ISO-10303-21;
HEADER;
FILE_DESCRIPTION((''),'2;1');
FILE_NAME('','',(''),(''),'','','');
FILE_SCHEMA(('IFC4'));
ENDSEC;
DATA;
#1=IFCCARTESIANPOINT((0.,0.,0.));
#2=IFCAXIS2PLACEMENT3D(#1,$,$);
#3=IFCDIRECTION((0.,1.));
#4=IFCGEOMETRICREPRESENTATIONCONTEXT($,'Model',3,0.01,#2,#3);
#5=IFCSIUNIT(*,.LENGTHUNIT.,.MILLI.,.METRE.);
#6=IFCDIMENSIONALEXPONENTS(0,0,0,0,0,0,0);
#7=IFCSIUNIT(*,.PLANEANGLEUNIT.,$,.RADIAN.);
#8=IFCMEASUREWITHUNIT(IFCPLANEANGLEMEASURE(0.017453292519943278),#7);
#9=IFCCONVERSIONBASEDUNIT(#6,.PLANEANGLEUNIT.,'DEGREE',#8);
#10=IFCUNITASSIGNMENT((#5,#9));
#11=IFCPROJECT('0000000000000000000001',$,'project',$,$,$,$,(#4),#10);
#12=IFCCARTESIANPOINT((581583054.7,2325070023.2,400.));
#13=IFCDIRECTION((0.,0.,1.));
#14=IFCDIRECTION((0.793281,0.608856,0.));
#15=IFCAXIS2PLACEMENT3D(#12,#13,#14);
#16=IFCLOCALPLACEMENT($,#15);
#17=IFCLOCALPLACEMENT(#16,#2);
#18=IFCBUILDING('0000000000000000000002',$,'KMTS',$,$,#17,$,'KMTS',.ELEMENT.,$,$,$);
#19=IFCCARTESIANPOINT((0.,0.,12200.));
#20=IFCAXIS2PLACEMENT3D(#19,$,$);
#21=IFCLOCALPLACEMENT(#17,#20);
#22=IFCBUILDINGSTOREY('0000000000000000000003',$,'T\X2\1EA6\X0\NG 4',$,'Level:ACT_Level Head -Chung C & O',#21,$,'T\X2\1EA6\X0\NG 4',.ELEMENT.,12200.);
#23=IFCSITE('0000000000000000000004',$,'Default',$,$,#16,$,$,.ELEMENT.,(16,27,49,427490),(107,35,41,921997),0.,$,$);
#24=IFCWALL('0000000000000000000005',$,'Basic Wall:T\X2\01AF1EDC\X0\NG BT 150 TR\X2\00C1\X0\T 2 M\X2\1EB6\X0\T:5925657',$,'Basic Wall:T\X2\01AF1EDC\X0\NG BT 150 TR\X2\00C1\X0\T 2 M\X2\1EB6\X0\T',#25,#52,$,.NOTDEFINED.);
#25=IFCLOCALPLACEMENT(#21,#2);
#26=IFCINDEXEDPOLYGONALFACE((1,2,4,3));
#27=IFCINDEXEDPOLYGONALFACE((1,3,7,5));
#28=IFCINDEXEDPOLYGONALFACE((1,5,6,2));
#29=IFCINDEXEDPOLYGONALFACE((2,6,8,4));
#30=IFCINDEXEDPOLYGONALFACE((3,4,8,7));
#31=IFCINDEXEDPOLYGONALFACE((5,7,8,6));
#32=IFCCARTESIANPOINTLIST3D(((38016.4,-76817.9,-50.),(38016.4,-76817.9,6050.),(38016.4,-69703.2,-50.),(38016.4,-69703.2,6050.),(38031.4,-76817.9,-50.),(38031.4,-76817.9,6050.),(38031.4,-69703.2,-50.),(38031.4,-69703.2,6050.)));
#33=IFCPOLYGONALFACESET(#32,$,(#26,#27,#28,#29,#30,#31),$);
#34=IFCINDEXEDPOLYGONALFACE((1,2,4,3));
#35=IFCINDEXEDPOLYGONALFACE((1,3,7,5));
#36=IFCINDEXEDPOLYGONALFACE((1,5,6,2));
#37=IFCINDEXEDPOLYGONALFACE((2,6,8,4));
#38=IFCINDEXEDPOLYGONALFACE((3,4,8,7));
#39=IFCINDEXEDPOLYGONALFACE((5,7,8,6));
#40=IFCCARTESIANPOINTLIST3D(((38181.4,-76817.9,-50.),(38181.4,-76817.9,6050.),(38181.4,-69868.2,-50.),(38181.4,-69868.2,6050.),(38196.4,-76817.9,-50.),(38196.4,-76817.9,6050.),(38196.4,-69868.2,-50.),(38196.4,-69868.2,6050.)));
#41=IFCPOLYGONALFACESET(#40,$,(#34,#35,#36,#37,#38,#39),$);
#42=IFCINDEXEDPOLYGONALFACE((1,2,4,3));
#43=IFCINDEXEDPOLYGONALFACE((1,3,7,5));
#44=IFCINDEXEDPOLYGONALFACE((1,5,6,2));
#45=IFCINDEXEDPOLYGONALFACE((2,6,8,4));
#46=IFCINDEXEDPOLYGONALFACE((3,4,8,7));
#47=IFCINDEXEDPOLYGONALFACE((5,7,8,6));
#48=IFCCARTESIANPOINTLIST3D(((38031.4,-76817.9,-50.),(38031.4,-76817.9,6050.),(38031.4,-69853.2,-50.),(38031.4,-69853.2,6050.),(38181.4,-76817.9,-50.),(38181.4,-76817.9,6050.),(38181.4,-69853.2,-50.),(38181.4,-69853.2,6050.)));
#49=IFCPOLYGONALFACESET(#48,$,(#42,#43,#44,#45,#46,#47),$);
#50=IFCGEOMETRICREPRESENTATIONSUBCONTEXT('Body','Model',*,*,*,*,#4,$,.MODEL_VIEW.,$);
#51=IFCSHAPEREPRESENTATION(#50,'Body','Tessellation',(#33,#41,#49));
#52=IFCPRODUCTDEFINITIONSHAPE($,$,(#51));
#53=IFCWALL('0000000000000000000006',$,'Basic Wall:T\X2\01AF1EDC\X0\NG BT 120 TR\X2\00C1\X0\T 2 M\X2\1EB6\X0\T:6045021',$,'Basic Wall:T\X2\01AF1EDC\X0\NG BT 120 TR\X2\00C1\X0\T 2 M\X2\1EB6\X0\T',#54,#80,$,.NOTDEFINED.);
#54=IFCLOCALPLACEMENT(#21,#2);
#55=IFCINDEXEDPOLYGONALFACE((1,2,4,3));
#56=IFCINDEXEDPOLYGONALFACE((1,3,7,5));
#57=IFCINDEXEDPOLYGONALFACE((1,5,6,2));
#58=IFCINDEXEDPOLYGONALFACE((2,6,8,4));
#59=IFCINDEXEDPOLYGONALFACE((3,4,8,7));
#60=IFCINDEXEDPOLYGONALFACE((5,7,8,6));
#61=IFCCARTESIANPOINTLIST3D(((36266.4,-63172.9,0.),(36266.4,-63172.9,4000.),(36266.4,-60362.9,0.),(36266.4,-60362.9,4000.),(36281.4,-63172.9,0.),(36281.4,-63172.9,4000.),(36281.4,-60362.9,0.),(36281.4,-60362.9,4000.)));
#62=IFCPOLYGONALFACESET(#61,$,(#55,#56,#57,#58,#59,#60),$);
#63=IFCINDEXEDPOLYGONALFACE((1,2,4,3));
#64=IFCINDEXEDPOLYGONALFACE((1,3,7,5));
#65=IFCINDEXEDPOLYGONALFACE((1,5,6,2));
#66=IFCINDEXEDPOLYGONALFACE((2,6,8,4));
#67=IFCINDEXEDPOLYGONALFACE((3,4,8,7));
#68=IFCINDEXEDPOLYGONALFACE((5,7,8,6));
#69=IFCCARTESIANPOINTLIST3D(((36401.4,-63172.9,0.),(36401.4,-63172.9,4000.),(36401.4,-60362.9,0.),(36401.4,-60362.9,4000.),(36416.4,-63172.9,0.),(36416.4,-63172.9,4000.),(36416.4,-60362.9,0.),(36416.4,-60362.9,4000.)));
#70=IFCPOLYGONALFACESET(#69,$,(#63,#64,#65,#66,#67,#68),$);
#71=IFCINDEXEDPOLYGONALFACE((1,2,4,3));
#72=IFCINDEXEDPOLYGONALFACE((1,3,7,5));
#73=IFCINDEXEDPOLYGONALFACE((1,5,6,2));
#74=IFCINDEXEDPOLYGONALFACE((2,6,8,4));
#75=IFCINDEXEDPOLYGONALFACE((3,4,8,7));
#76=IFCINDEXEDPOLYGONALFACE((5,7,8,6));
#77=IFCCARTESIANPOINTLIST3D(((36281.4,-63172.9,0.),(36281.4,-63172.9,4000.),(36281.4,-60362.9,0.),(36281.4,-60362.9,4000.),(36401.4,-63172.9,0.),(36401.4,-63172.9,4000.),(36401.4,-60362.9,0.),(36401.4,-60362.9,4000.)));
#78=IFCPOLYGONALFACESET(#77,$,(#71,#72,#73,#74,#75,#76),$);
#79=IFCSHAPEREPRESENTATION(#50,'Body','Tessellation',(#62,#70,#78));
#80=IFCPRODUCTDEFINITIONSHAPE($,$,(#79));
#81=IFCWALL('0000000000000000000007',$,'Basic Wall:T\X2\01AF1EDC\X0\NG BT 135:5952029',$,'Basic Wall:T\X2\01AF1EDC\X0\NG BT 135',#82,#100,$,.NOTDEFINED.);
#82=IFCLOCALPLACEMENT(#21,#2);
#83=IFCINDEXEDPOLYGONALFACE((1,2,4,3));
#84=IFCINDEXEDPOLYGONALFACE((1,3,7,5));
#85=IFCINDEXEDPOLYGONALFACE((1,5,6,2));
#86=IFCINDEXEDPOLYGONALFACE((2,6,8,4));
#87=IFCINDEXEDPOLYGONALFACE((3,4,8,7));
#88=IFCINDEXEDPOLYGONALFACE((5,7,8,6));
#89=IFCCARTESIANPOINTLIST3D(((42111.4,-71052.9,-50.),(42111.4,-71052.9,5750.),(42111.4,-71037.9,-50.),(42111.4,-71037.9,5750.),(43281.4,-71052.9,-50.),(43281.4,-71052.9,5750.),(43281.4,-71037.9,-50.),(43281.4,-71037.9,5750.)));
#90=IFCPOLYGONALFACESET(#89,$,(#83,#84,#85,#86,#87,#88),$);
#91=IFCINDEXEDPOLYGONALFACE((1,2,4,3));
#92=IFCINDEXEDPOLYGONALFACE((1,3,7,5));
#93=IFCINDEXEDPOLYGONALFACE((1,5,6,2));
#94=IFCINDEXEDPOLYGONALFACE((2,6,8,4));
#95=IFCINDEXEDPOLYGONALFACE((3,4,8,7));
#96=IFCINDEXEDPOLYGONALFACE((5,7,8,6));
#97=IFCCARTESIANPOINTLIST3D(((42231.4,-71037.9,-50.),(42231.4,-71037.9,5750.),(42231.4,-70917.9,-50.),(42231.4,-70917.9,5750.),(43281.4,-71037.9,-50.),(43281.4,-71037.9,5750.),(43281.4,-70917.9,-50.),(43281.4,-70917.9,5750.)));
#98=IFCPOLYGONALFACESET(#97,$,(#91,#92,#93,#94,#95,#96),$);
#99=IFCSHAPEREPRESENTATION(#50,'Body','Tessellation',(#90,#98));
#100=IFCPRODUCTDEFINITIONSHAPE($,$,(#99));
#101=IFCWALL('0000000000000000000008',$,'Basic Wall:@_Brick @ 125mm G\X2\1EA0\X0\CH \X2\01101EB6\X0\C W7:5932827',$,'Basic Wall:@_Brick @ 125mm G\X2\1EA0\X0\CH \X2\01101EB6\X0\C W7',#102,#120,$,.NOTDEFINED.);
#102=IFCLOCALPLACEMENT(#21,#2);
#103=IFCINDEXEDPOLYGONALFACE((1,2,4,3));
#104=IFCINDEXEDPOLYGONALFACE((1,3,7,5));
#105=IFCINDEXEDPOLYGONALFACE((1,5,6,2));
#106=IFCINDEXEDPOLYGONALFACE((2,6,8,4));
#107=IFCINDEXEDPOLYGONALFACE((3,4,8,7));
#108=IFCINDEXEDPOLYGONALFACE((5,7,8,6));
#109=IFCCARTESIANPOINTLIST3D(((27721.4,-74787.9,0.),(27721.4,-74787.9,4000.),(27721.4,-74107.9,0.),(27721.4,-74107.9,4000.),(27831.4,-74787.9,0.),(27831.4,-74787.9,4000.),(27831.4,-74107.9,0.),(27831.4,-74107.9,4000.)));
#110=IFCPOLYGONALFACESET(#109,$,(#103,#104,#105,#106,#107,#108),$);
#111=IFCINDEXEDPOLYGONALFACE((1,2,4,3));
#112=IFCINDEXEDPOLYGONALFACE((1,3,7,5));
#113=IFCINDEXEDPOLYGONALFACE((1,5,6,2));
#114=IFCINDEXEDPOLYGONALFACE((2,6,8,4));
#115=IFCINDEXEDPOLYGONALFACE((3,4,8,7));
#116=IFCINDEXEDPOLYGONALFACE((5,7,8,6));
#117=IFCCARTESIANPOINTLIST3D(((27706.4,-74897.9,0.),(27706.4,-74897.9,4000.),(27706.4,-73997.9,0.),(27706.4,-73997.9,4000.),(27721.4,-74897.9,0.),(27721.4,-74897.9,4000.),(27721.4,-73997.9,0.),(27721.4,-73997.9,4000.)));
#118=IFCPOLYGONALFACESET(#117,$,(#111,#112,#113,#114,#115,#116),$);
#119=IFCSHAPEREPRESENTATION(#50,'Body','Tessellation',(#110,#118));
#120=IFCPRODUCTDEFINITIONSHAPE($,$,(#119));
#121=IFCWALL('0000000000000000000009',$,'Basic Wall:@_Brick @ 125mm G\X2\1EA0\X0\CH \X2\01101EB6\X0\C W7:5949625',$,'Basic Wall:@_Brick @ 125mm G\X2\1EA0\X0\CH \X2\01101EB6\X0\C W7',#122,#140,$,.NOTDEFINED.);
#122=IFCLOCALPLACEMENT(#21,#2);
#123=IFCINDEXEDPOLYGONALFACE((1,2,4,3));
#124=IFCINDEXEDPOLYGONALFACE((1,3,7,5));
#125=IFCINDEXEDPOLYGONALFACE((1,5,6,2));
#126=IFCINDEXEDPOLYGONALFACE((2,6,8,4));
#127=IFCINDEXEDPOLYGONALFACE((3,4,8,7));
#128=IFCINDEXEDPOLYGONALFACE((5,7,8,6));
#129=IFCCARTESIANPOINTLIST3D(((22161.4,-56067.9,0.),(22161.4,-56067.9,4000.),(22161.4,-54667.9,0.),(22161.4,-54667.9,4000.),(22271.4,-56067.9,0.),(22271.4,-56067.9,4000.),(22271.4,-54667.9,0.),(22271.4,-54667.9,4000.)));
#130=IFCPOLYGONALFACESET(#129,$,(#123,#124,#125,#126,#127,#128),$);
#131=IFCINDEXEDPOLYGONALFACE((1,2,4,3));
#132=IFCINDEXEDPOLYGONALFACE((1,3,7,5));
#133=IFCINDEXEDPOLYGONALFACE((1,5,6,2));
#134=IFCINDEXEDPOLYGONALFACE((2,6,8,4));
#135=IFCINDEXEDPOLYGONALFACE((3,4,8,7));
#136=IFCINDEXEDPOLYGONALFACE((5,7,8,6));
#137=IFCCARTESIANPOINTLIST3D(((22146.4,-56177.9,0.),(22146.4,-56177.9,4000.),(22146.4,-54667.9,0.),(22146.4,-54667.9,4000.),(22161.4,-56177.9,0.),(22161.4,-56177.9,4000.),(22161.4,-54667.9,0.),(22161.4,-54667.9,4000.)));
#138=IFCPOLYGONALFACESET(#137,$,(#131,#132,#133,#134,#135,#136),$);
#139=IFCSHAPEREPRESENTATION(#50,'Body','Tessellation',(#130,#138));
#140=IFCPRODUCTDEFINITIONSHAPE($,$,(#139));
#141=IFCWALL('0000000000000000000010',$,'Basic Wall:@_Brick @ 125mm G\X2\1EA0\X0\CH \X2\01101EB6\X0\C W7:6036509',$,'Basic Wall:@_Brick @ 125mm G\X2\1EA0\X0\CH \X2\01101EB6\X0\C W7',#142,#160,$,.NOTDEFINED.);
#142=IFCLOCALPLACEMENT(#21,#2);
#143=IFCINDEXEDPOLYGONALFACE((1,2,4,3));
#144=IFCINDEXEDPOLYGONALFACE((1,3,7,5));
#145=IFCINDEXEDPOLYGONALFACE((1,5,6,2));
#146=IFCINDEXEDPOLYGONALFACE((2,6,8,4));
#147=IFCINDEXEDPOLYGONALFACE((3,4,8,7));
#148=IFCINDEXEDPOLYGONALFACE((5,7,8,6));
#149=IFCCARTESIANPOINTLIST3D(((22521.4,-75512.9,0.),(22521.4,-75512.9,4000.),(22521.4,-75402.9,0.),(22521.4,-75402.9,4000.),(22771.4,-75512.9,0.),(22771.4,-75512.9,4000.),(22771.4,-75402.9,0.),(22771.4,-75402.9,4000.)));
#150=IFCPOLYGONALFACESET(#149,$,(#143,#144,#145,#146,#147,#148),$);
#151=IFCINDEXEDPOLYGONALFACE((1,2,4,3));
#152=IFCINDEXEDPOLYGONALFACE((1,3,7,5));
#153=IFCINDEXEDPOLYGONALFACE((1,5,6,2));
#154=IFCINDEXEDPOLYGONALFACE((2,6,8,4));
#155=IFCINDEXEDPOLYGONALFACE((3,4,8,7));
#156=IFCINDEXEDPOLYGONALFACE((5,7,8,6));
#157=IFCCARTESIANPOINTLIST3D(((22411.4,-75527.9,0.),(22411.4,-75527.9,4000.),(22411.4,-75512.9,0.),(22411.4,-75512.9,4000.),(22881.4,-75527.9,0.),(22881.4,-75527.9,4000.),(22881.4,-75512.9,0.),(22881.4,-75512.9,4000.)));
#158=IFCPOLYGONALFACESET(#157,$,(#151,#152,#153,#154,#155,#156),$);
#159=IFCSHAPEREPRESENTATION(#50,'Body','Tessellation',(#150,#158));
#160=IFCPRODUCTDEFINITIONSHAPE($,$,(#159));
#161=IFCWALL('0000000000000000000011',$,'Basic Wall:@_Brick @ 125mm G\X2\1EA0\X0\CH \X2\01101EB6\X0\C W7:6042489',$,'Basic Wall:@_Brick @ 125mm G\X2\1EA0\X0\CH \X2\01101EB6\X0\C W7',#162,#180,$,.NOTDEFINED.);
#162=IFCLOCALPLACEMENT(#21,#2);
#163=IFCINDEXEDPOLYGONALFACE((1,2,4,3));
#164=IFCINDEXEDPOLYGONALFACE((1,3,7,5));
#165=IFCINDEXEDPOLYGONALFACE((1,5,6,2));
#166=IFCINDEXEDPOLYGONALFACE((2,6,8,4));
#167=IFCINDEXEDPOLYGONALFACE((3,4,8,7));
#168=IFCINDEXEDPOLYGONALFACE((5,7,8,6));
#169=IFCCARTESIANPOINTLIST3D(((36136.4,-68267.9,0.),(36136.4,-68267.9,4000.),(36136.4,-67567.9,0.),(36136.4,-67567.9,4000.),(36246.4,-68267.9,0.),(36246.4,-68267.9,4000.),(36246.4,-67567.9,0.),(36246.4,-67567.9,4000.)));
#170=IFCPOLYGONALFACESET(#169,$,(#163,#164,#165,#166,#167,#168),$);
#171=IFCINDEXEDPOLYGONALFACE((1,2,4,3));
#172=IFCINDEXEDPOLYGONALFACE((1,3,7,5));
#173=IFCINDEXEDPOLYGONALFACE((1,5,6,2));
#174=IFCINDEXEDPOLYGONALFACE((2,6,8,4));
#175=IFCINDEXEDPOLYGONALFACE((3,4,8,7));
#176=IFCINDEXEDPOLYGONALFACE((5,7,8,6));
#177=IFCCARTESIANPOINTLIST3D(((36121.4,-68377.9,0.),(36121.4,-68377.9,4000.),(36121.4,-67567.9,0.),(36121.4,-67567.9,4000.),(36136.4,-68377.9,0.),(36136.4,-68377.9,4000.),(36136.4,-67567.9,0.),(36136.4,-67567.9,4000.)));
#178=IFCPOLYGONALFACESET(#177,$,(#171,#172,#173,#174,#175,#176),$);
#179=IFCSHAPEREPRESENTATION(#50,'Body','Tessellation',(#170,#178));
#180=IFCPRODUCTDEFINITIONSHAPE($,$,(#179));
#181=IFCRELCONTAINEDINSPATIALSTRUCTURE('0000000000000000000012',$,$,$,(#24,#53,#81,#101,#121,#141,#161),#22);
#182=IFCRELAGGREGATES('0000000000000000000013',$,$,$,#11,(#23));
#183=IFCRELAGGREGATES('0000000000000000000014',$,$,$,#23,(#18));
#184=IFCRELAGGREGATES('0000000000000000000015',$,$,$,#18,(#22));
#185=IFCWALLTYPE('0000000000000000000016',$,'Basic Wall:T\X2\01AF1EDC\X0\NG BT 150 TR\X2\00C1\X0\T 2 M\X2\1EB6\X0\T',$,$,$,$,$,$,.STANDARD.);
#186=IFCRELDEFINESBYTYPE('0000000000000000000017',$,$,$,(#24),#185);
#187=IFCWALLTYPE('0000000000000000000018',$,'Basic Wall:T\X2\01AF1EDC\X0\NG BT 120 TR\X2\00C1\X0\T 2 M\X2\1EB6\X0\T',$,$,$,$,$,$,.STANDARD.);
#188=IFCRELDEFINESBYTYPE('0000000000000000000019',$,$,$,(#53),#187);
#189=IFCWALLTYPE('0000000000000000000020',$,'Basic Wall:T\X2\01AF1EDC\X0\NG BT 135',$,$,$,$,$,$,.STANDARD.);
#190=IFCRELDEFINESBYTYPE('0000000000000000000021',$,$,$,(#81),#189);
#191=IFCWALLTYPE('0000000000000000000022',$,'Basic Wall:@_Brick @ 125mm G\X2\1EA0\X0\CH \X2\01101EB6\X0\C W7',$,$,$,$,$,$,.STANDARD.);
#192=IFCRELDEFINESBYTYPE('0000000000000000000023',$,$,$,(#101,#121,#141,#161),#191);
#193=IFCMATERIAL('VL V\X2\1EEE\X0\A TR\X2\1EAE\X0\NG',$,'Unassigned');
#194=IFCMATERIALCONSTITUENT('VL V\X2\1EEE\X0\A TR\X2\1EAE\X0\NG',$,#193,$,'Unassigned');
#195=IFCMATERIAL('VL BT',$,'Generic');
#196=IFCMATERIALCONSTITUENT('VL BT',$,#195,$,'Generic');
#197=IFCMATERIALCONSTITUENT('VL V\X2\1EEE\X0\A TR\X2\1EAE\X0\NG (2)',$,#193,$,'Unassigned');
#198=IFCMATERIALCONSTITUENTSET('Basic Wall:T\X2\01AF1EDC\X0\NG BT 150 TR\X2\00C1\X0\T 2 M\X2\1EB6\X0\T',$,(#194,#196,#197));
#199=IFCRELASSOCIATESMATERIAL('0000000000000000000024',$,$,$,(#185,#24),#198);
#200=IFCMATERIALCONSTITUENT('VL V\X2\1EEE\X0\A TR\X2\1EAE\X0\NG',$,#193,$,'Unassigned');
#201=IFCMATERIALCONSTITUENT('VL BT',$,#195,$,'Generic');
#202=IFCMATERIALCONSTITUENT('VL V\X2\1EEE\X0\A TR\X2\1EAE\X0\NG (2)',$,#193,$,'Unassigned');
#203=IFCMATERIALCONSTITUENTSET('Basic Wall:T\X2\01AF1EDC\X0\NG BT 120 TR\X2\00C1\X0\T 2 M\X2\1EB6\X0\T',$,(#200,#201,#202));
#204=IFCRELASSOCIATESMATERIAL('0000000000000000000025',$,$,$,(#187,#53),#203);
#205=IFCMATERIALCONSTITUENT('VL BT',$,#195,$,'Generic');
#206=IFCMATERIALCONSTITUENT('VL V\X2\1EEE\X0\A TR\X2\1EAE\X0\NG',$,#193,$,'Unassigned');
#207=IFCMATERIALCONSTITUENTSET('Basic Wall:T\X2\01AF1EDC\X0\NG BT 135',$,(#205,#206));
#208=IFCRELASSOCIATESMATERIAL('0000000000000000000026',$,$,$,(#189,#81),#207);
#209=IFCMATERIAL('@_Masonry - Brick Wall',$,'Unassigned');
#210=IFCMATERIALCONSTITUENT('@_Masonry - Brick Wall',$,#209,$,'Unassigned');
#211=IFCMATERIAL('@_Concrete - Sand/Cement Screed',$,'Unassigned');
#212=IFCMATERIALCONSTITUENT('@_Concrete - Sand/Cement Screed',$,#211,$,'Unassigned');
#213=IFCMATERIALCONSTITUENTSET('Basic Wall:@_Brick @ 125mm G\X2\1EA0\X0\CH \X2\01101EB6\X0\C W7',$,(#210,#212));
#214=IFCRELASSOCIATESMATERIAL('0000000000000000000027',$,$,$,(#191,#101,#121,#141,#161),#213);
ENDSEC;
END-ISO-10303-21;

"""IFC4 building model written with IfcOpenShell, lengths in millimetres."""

from ifc_helpers import new_model, entity, si_unit, converted_unit, direction, frame, origin, place, context, subcontext, project, spatial, indexed_curve, outline, extrude, material, constituent, constituent_set, type_object, element, save


model = new_model("IFC4")

# Units and contexts
model_context = context("Model", 3, precision=0.01, world=origin(), true_north=direction((0.0, 1.0)))
body_context = subcontext(model_context, "Body", "Model", "MODEL_VIEW")
ifc_project = project(units=[si_unit("LENGTHUNIT", "METRE", prefix="MILLI"), converted_unit("PLANEANGLEUNIT", "DEGREE", entity("IfcPlaneAngleMeasure", 0.017453292519943278), si_unit("PLANEANGLEUNIT", "RADIAN"), dimensions=[0, 0, 0, 0, 0, 0, 0])], contexts=[model_context])

# Site, building, storey
site_placement = place(None, frame((581583054.7, 2325070023.2, 400.0), z_axis=(0.0, 0.0, 1.0), x_axis=(0.793281, 0.608856, 0.0)))
site = spatial("IfcSite", under=ifc_project, at=site_placement, Name="Default", CompositionType="ELEMENT", RefLatitude=(16, 27, 49, 427490), RefLongitude=(107, 35, 41, 921997), RefElevation=0.0)
building_placement = place(site_placement, origin())
building = spatial("IfcBuilding", under=site, at=building_placement, Name="KMTS", LongName="KMTS", CompositionType="ELEMENT")
storey_placement = place(building_placement, frame((0.0, 0.0, 12200.0)))
storey = spatial("IfcBuildingStorey", under=building, at=storey_placement, Name="TẦNG 4", ObjectType="Level:ACT_Level Head -Chung C & O", LongName="TẦNG 4", CompositionType="ELEMENT", Elevation=12200.0)

# Shared definitions
ifc_material_1 = material(Name="VL VỮA TRẮNG", Category="Unassigned")
ifc_constituent_1 = constituent(ifc_material_1, Name="VL VỮA TRẮNG", Category="Unassigned")
ifc_material_2 = material(Name="VL BT", Category="Generic")
ifc_constituent_2 = constituent(ifc_material_2, Name="VL BT", Category="Generic")
ifc_constituent_3 = constituent(ifc_material_1, Name="VL VỮA TRẮNG (2)", Category="Unassigned")
ifc_constituent_set_1 = constituent_set(constituents=[ifc_constituent_1, ifc_constituent_2, ifc_constituent_3], Name="Basic Wall:TƯỜNG BT 150 TRÁT 2 MẶT")
wall_type_1 = type_object("IfcWallType", Name="Basic Wall:TƯỜNG BT 150 TRÁT 2 MẶT", PredefinedType="STANDARD", material=ifc_constituent_set_1)

# Wall
wall_1_placement = place(storey_placement, frame((38106.4, -69868.2, -50.0), z_axis=(0.0, 0.0, 1.0), x_axis=(0.0, -1.0, 0.0)))
element("IfcWall", 1, at=wall_1_placement, inside=storey, type_object=wall_type_1, material=ifc_constituent_set_1, Name="Basic Wall:TƯỜNG BT 150 TRÁT 2 MẶT:5925657", ObjectType="Basic Wall:TƯỜNG BT 150 TRÁT 2 MẶT", PredefinedType="NOTDEFINED", context=body_context, shape_type="SweptSolid", body=[
    extrude(outline(indexed_curve([(-7.5, -3557.4), (7.5, -3557.4), (7.5, 3557.4), (-7.5, 3557.4), (-7.5, -3557.4)], self_intersect=False)), frame((3392.4, -82.5, 0.0), z_axis=(0.0, 0.0, 1.0), x_axis=(0.0, 1.0, 0.0)), (0.0, 0.0, 1.0), 6100.0),
    extrude(outline(indexed_curve([(-7.5, -3474.9), (7.5, -3474.9), (7.5, 3474.9), (-7.5, 3474.9), (-7.5, -3474.9)], self_intersect=False)), frame((3474.9, 82.5, 0.0), z_axis=(0.0, 0.0, 1.0), x_axis=(0.0, -1.0, 0.0)), (0.0, 0.0, 1.0), 6100.0),
    extrude(outline(indexed_curve([(-3482.4, -75.0), (3482.4, -75.0), (3482.4, 75.0), (-3482.4, 75.0), (-3482.4, -75.0)], self_intersect=False)), frame((3467.4, 0.0, 0.0)), (0.0, 0.0, 1.0), 6100.0),
])

# Shared definitions
ifc_constituent_4 = constituent(ifc_material_1, Name="VL VỮA TRẮNG", Category="Unassigned")
ifc_constituent_5 = constituent(ifc_material_2, Name="VL BT", Category="Generic")
ifc_constituent_6 = constituent(ifc_material_1, Name="VL VỮA TRẮNG (2)", Category="Unassigned")
ifc_constituent_set_2 = constituent_set(constituents=[ifc_constituent_4, ifc_constituent_5, ifc_constituent_6], Name="Basic Wall:TƯỜNG BT 120 TRÁT 2 MẶT")
wall_type_2 = type_object("IfcWallType", Name="Basic Wall:TƯỜNG BT 120 TRÁT 2 MẶT", PredefinedType="STANDARD", material=ifc_constituent_set_2)

# Walls
wall_2_placement = place(storey_placement, frame((36341.4, -60362.9, 0.0), z_axis=(0.0, 0.0, 1.0), x_axis=(0.0, -1.0, 0.0)))
element("IfcWall", 2, at=wall_2_placement, inside=storey, type_object=wall_type_2, material=ifc_constituent_set_2, Name="Basic Wall:TƯỜNG BT 120 TRÁT 2 MẶT:6045021", ObjectType="Basic Wall:TƯỜNG BT 120 TRÁT 2 MẶT", PredefinedType="NOTDEFINED", context=body_context, shape_type="SweptSolid", body=[
    extrude(outline(indexed_curve([(-7.5, -1405.0), (7.5, -1405.0), (7.5, 1405.0), (-7.5, 1405.0), (-7.5, -1405.0)], self_intersect=False)), frame((1405.0, -67.5, 0.0), z_axis=(0.0, 0.0, 1.0), x_axis=(0.0, 1.0, 0.0)), (0.0, 0.0, 1.0), 4000.0),
    extrude(outline(indexed_curve([(-7.5, -1405.0), (7.5, -1405.0), (7.5, 1405.0), (-7.5, 1405.0), (-7.5, -1405.0)], self_intersect=False)), frame((1405.0, 67.5, 0.0), z_axis=(0.0, 0.0, 1.0), x_axis=(0.0, -1.0, 0.0)), (0.0, 0.0, 1.0), 4000.0),
    extrude(outline(indexed_curve([(-1405.0, -60.0), (1405.0, -60.0), (1405.0, 60.0), (-1405.0, 60.0), (-1405.0, -60.0)], self_intersect=False)), frame((1405.0, 0.0, 0.0)), (0.0, 0.0, 1.0), 4000.0),
])
ifc_constituent_7 = constituent(ifc_material_2, Name="VL BT", Category="Generic")
ifc_constituent_8 = constituent(ifc_material_1, Name="VL VỮA TRẮNG", Category="Unassigned")
ifc_constituent_set_3 = constituent_set(constituents=[ifc_constituent_7, ifc_constituent_8], Name="Basic Wall:TƯỜNG BT 135")
wall_type_3 = type_object("IfcWallType", Name="Basic Wall:TƯỜNG BT 135", PredefinedType="STANDARD", material=ifc_constituent_set_3)
wall_3_placement = place(storey_placement, frame((42231.4, -70985.4, -50.0)))
element("IfcWall", 3, at=wall_3_placement, inside=storey, type_object=wall_type_3, material=ifc_constituent_set_3, Name="Basic Wall:TƯỜNG BT 135:5952029", ObjectType="Basic Wall:TƯỜNG BT 135", PredefinedType="NOTDEFINED", context=body_context, shape_type="SweptSolid", body=[
    extrude(outline(indexed_curve([(-7.5, -585.0), (7.5, -585.0), (7.5, 585.0), (-7.5, 585.0), (-7.5, -585.0)], self_intersect=False)), frame((465.0, -60.0, 0.0), z_axis=(0.0, 0.0, 1.0), x_axis=(0.0, 1.0, 0.0)), (0.0, 0.0, 1.0), 5800.0),
    extrude(outline(indexed_curve([(-60.0, -525.0), (60.0, -525.0), (60.0, 525.0), (-60.0, 525.0), (-60.0, -525.0)], self_intersect=False)), frame((525.0, 7.5, 0.0), z_axis=(0.0, 0.0, 1.0), x_axis=(0.0, -1.0, 0.0)), (0.0, 0.0, 1.0), 5800.0),
])
ifc_material_3 = material(Name="@_Masonry - Brick Wall", Category="Unassigned")
ifc_constituent_9 = constituent(ifc_material_3, Name="@_Masonry - Brick Wall", Category="Unassigned")
ifc_material_4 = material(Name="@_Concrete - Sand/Cement Screed", Category="Unassigned")
ifc_constituent_10 = constituent(ifc_material_4, Name="@_Concrete - Sand/Cement Screed", Category="Unassigned")
ifc_constituent_set_4 = constituent_set(constituents=[ifc_constituent_9, ifc_constituent_10], Name="Basic Wall:@_Brick @ 125mm GẠCH ĐẶC W7")
wall_type_4 = type_object("IfcWallType", Name="Basic Wall:@_Brick @ 125mm GẠCH ĐẶC W7", PredefinedType="STANDARD", material=ifc_constituent_set_4)
wall_4_placement = place(storey_placement, frame((27768.9, -74107.9, 0.0), z_axis=(0.0, 0.0, 1.0), x_axis=(0.0, -1.0, 0.0)))
element("IfcWall", 4, at=wall_4_placement, inside=storey, type_object=wall_type_4, material=ifc_constituent_set_4, Name="Basic Wall:@_Brick @ 125mm GẠCH ĐẶC W7:5932827", ObjectType="Basic Wall:@_Brick @ 125mm GẠCH ĐẶC W7", PredefinedType="NOTDEFINED", context=body_context, shape_type="SweptSolid", body=[
    extrude(outline(indexed_curve([(-55.0, -340.0), (55.0, -340.0), (55.0, 340.0), (-55.0, 340.0), (-55.0, -340.0)], self_intersect=False)), frame((340.0, 7.5, 0.0), z_axis=(0.0, 0.0, 1.0), x_axis=(0.0, -1.0, 0.0)), (0.0, 0.0, 1.0), 4000.0),
    extrude(outline(indexed_curve([(-7.5, -450.0), (7.5, -450.0), (7.5, 450.0), (-7.5, 450.0), (-7.5, -450.0)], self_intersect=False)), frame((340.0, -55.0, 0.0), z_axis=(0.0, 0.0, 1.0), x_axis=(0.0, 1.0, 0.0)), (0.0, 0.0, 1.0), 4000.0),
])
wall_5_placement = place(storey_placement, frame((22208.9, -54667.9, 0.0), z_axis=(0.0, 0.0, 1.0), x_axis=(0.0, -1.0, 0.0)))
element("IfcWall", 5, at=wall_5_placement, inside=storey, type_object=wall_type_4, material=ifc_constituent_set_4, Name="Basic Wall:@_Brick @ 125mm GẠCH ĐẶC W7:5949625", ObjectType="Basic Wall:@_Brick @ 125mm GẠCH ĐẶC W7", PredefinedType="NOTDEFINED", context=body_context, shape_type="SweptSolid", body=[
    extrude(outline(indexed_curve([(-55.0, -700.0), (55.0, -700.0), (55.0, 700.0), (-55.0, 700.0), (-55.0, -700.0)], self_intersect=False)), frame((700.0, 7.5, 0.0), z_axis=(0.0, 0.0, 1.0), x_axis=(0.0, -1.0, 0.0)), (0.0, 0.0, 1.0), 4000.0),
    extrude(outline(indexed_curve([(-7.5, -755.0), (7.5, -755.0), (7.5, 755.0), (-7.5, 755.0), (-7.5, -755.0)], self_intersect=False)), frame((755.0, -55.0, 0.0), z_axis=(0.0, 0.0, 1.0), x_axis=(0.0, 1.0, 0.0)), (0.0, 0.0, 1.0), 4000.0),
])
wall_6_placement = place(storey_placement, frame((22521.4, -75465.4, 0.0)))
element("IfcWall", 6, at=wall_6_placement, inside=storey, type_object=wall_type_4, material=ifc_constituent_set_4, Name="Basic Wall:@_Brick @ 125mm GẠCH ĐẶC W7:6036509", ObjectType="Basic Wall:@_Brick @ 125mm GẠCH ĐẶC W7", PredefinedType="NOTDEFINED", context=body_context, shape_type="SweptSolid", body=[
    extrude(outline(indexed_curve([(-55.0, -125.0), (55.0, -125.0), (55.0, 125.0), (-55.0, 125.0), (-55.0, -125.0)], self_intersect=False)), frame((125.0, 7.5, 0.0), z_axis=(0.0, 0.0, 1.0), x_axis=(0.0, -1.0, 0.0)), (0.0, 0.0, 1.0), 4000.0),
    extrude(outline(indexed_curve([(-7.5, -235.0), (7.5, -235.0), (7.5, 235.0), (-7.5, 235.0), (-7.5, -235.0)], self_intersect=False)), frame((125.0, -55.0, 0.0), z_axis=(0.0, 0.0, 1.0), x_axis=(0.0, 1.0, 0.0)), (0.0, 0.0, 1.0), 4000.0),
])
wall_7_placement = place(storey_placement, frame((36183.9, -68267.9, 0.0), z_axis=(0.0, 0.0, 1.0), x_axis=(0.0, 1.0, 0.0)))
element("IfcWall", 7, at=wall_7_placement, inside=storey, type_object=wall_type_4, material=ifc_constituent_set_4, Name="Basic Wall:@_Brick @ 125mm GẠCH ĐẶC W7:6042489", ObjectType="Basic Wall:@_Brick @ 125mm GẠCH ĐẶC W7", PredefinedType="NOTDEFINED", context=body_context, shape_type="SweptSolid", body=[
    extrude(outline(indexed_curve([(-55.0, -350.0), (55.0, -350.0), (55.0, 350.0), (-55.0, 350.0), (-55.0, -350.0)], self_intersect=False)), frame((350.0, -7.5, 0.0), z_axis=(0.0, 0.0, 1.0), x_axis=(0.0, 1.0, 0.0)), (0.0, 0.0, 1.0), 4000.0),
    extrude(outline(indexed_curve([(-7.5, -405.0), (7.5, -405.0), (7.5, 405.0), (-7.5, 405.0), (-7.5, -405.0)], self_intersect=False)), frame((295.0, 55.0, 0.0), z_axis=(0.0, 0.0, 1.0), x_axis=(0.0, -1.0, 0.0)), (0.0, 0.0, 1.0), 4000.0),
])

save(model, "model.ifc")
